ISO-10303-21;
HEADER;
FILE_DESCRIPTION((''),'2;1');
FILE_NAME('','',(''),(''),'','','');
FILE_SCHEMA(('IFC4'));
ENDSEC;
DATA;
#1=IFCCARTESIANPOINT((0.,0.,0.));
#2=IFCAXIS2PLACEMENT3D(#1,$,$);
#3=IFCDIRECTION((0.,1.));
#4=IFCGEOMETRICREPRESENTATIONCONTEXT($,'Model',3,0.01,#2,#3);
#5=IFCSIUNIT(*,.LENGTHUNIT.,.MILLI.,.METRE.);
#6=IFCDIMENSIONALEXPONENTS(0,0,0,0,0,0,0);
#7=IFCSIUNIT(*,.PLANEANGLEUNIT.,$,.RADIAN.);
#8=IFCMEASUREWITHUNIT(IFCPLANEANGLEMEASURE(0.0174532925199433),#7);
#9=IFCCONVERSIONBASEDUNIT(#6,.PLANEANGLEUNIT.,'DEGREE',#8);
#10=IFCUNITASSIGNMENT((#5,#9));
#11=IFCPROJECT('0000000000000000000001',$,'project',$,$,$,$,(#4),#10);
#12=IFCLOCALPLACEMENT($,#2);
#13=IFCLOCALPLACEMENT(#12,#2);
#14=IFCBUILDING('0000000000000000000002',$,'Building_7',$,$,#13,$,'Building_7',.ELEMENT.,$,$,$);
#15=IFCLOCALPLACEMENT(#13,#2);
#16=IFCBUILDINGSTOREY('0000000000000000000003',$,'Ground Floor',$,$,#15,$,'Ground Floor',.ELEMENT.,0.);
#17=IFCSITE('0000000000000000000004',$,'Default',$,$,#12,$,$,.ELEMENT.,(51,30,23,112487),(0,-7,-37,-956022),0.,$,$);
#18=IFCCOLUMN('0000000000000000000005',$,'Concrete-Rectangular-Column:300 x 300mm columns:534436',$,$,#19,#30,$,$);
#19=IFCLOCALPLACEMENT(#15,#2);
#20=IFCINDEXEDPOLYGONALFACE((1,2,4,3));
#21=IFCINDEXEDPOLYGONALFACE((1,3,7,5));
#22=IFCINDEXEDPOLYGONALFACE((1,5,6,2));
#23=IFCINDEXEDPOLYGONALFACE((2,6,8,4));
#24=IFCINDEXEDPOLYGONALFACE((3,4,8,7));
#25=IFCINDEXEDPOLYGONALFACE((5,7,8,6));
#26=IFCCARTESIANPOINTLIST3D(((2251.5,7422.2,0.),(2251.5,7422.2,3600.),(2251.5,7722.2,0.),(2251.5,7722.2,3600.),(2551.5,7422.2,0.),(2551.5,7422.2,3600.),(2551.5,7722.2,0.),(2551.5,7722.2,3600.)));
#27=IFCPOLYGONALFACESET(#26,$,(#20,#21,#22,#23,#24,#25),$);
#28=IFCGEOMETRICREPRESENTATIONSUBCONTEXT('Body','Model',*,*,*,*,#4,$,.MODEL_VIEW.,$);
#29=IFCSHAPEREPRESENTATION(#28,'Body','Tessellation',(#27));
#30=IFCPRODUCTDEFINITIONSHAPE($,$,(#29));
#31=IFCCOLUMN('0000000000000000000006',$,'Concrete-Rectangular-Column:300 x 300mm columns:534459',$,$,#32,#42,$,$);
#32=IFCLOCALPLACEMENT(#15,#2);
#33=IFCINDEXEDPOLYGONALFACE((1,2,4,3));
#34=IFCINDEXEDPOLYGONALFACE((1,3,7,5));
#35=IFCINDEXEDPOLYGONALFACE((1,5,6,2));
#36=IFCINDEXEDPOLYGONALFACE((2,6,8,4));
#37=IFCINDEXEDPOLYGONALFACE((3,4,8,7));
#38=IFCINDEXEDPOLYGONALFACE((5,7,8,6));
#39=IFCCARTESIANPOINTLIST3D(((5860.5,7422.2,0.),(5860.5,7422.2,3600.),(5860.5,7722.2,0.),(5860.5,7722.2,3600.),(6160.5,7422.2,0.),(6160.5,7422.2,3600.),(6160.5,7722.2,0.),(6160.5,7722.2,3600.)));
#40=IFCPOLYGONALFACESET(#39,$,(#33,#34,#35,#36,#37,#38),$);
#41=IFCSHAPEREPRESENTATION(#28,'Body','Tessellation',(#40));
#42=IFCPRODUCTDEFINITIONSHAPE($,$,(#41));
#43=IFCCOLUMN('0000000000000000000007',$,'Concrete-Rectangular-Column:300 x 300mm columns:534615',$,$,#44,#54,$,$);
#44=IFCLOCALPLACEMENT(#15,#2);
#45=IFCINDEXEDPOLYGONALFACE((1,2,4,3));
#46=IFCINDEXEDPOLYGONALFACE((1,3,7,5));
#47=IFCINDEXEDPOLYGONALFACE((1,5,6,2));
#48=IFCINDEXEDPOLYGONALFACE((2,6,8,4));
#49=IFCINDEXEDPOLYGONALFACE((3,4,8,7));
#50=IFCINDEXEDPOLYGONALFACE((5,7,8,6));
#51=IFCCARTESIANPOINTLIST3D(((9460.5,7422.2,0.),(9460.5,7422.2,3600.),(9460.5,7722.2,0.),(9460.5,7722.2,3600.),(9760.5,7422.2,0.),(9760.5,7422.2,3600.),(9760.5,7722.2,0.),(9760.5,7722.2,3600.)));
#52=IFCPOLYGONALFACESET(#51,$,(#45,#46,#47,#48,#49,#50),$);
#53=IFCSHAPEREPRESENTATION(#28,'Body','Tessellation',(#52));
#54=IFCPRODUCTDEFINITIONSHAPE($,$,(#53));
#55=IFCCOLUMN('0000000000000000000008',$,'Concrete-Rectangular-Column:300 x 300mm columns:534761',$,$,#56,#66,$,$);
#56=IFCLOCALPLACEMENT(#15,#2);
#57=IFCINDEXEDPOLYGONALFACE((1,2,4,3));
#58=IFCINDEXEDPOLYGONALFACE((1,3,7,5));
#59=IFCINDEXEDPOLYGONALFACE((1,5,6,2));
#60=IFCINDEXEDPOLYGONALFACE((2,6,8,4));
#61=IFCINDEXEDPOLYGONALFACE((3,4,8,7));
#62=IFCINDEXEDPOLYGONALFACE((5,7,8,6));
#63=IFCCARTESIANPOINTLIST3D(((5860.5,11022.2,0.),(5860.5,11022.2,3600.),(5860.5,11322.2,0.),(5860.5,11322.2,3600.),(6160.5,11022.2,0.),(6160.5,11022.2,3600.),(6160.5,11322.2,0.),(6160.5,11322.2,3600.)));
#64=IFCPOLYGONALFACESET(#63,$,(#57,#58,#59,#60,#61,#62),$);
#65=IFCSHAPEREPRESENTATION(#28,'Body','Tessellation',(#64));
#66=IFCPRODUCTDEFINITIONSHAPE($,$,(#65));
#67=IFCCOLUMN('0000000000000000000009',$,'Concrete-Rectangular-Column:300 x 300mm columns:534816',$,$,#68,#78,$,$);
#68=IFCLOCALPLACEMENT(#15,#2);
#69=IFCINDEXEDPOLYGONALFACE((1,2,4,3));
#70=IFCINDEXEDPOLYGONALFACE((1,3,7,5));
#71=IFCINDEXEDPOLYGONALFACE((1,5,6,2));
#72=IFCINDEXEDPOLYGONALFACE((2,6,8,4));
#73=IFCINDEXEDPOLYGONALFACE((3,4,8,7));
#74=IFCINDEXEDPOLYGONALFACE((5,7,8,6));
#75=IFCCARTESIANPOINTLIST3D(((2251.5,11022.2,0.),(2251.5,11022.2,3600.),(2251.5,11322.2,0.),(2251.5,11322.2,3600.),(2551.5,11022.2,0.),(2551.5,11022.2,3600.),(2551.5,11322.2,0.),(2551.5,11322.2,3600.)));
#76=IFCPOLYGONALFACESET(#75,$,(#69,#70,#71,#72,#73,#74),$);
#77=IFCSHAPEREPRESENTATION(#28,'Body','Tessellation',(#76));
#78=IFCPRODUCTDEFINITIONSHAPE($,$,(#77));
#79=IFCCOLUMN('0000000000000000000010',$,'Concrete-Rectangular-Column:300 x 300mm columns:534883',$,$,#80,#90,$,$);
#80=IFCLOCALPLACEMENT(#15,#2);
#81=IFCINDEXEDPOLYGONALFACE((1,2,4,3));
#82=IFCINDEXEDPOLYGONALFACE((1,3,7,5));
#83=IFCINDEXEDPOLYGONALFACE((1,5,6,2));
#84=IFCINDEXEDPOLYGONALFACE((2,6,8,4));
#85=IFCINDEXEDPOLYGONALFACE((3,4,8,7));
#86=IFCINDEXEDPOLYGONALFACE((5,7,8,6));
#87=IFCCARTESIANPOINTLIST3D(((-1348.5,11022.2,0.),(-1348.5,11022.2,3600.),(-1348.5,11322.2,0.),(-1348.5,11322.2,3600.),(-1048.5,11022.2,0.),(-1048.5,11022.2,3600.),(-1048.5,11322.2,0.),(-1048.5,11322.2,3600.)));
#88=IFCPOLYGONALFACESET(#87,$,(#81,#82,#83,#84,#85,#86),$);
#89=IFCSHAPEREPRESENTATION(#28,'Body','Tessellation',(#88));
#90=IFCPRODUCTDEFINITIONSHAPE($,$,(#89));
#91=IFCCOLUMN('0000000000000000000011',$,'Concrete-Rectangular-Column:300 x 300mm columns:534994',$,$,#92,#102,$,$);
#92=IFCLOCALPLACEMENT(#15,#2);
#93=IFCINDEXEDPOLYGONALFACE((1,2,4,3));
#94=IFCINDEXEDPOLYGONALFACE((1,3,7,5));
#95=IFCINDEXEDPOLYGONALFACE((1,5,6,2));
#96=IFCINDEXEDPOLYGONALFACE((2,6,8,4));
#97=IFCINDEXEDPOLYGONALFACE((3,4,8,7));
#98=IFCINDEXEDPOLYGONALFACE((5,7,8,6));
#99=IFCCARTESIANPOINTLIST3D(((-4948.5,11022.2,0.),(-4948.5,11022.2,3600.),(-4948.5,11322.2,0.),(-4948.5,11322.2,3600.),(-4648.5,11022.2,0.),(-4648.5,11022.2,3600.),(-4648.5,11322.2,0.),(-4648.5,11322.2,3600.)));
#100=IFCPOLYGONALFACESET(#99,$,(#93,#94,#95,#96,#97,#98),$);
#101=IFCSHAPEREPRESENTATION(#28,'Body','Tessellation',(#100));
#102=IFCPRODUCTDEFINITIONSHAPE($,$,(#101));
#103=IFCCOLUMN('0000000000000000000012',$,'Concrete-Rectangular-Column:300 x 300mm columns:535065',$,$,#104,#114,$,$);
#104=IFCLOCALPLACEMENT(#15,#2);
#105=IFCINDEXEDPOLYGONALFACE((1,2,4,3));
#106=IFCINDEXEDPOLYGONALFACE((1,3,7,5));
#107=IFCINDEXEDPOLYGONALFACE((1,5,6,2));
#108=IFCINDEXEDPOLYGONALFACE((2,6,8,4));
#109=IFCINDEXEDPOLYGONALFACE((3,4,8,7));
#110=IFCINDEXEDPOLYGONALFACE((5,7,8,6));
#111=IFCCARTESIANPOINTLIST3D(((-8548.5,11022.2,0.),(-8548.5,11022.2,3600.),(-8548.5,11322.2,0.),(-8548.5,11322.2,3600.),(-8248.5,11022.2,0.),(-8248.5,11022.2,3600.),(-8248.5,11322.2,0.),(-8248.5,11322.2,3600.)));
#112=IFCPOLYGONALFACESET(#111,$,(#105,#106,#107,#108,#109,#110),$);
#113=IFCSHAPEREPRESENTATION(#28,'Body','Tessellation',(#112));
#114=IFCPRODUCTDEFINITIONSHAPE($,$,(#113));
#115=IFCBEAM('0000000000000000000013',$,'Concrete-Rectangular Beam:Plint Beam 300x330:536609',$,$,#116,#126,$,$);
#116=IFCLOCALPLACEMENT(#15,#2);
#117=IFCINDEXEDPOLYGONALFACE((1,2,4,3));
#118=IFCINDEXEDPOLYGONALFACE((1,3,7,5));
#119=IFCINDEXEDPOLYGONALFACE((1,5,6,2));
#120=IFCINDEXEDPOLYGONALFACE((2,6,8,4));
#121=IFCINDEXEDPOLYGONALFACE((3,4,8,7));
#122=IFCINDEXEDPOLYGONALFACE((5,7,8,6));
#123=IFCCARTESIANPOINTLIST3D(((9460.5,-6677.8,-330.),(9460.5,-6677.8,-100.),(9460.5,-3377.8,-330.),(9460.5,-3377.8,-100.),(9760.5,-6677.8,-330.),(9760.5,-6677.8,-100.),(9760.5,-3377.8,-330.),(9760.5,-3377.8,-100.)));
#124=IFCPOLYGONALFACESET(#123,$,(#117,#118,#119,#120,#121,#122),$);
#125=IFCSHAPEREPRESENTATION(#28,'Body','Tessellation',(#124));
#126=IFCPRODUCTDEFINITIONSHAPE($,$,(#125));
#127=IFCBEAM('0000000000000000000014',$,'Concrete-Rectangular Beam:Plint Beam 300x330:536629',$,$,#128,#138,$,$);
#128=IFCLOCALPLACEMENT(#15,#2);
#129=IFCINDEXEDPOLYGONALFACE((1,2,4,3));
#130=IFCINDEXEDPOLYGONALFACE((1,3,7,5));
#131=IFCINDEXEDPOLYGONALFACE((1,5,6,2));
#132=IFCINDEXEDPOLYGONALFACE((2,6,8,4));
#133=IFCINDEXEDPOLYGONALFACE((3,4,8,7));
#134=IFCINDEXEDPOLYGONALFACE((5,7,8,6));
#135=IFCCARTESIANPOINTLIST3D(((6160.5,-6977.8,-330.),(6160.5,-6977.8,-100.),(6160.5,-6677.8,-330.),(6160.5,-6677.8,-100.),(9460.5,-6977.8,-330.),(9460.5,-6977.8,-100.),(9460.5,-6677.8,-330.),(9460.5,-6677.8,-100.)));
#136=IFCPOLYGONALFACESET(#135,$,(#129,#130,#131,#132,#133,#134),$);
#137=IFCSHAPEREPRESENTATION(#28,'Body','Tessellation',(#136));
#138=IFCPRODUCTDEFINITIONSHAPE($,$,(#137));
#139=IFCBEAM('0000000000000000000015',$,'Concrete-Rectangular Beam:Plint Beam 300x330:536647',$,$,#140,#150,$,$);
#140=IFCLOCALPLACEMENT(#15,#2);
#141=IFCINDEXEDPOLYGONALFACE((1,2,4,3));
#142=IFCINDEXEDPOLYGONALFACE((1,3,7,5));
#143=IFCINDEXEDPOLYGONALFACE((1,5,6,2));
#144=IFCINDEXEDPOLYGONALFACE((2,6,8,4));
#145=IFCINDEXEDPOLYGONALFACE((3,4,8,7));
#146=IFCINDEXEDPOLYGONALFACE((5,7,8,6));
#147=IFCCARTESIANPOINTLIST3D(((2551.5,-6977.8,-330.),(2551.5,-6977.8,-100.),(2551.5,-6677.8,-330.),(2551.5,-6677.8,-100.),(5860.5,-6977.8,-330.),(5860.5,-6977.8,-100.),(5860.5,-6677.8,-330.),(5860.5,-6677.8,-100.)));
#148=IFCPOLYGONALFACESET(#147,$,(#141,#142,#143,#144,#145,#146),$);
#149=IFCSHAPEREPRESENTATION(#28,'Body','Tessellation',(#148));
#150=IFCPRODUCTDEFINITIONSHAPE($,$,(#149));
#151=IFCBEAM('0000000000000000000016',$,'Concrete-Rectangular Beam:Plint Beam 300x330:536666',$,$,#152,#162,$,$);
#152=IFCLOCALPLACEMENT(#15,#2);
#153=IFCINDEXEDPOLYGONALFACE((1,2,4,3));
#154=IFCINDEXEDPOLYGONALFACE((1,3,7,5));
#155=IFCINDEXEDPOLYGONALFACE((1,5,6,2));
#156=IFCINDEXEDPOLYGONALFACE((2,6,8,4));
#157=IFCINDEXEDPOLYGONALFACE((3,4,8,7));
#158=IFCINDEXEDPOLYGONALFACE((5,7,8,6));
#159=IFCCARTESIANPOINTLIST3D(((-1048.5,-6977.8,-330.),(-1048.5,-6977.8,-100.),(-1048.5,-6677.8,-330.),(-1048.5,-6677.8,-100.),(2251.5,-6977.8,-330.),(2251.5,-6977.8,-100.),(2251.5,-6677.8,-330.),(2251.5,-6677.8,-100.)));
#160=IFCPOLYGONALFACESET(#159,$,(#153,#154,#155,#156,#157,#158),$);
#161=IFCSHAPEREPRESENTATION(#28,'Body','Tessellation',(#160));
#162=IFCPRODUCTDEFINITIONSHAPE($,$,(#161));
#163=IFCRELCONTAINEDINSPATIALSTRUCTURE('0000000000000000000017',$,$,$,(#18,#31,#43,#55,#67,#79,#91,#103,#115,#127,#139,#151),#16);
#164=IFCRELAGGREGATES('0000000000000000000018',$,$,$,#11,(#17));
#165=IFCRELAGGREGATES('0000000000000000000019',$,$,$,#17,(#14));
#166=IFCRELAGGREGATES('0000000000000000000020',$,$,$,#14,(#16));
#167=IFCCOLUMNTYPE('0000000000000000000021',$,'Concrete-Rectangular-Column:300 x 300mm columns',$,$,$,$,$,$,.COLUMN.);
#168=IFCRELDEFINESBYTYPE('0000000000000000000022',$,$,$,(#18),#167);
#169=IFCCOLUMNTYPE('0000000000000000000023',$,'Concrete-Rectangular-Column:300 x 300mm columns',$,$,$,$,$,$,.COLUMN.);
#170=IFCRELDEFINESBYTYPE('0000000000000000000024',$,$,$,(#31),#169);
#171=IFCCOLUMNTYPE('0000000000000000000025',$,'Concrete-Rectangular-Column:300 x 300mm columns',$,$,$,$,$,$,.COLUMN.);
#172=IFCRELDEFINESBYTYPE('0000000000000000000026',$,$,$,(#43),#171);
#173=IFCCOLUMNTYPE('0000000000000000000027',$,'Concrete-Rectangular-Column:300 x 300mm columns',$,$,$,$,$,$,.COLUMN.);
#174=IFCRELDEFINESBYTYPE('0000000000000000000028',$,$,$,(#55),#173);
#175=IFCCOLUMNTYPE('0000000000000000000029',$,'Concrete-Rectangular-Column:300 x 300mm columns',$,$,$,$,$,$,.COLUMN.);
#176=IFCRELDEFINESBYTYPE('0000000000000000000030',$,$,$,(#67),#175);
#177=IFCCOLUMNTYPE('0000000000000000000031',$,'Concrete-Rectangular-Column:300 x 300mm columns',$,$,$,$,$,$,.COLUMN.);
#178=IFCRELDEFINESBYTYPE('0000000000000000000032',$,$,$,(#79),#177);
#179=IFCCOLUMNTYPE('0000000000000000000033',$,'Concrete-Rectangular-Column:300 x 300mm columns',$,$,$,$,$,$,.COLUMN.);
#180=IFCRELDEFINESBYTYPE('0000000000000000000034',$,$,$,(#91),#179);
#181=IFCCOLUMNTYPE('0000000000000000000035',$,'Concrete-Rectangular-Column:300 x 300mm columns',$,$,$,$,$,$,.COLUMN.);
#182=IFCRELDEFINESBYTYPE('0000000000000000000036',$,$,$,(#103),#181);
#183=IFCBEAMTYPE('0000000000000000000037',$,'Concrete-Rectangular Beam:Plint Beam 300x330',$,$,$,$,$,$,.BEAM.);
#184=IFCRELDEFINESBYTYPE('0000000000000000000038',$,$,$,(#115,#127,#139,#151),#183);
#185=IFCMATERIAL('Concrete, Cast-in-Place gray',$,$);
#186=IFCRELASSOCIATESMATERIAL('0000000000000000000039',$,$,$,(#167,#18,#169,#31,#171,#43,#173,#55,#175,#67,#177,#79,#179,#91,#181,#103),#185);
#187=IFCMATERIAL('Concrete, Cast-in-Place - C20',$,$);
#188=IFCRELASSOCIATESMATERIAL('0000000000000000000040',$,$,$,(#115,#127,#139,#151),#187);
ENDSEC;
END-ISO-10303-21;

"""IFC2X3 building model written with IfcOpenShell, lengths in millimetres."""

from ifc_helpers import new_model, entity, si_unit, converted_unit, direction, frame, frame_2d, origin, place, context, subcontext, project, spatial, rectangle, extrude, source, transform, mapped, material, type_object, type_shapes, element, save


model = new_model("IFC2X3")

# Units and contexts
model_context = context("Model", 3, precision=0.01, world=origin(), true_north=direction((0.0, 1.0)))
body_context = subcontext(model_context, "Body", "Model", "MODEL_VIEW")
ifc_project = project(units=[si_unit("LENGTHUNIT", "METRE", prefix="MILLI"), converted_unit("PLANEANGLEUNIT", "DEGREE", entity("IfcPlaneAngleMeasure", 0.0174532925199433), si_unit("PLANEANGLEUNIT", "RADIAN"), dimensions=[0, 0, 0, 0, 0, 0, 0])], contexts=[model_context])

# Site, building, storey
site_placement = place(None, origin())
site = spatial("IfcSite", under=ifc_project, at=site_placement, Name="Default", CompositionType="ELEMENT", RefLatitude=(51, 30, 23, 112487), RefLongitude=(0, -7, -37, -956022), RefElevation=0.0)
building_placement = place(site_placement, origin())
building = spatial("IfcBuilding", under=site, at=building_placement, Name="Building_7", LongName="Building_7", CompositionType="ELEMENT")
storey_placement = place(building_placement, origin())
storey = spatial("IfcBuildingStorey", under=building, at=storey_placement, Name="Ground Floor", LongName="Ground Floor", CompositionType="ELEMENT", Elevation=0.0)

# Columns
ifc_material_1 = material(Name="Concrete, Cast-in-Place gray")
column_type_1 = type_object("IfcColumnType", Name="Concrete-Rectangular-Column:300 x 300mm columns", PredefinedType="COLUMN", material=ifc_material_1)
shared_shape_1 = source(origin(), body_context, "Body", "SweptSolid", [
    extrude(rectangle(XDim=300.0, YDim=300.0, at=frame_2d((0.0, 0.0), x_axis=(1.0, 0.0))), frame((2401.5, 7572.2, 0.0), z_axis=(0.0, 0.0, 1.0), x_axis=(-1.0, 0.0, 0.0)), (0.0, 0.0, 1.0), 3600.0),
])
type_shapes(column_type_1, [shared_shape_1])
column_1_placement = place(storey_placement, origin())
element("IfcColumn", 1, at=column_1_placement, inside=storey, type_object=column_type_1, material=ifc_material_1, Name="Concrete-Rectangular-Column:300 x 300mm columns:534436", context=body_context, shape_type="MappedRepresentation", body=[
    mapped(shared_shape_1, transform((0.0, 0.0, 0.0), scale=1.0)),
])
column_type_2 = type_object("IfcColumnType", Name="Concrete-Rectangular-Column:300 x 300mm columns", PredefinedType="COLUMN", material=ifc_material_1)
shared_shape_2 = source(origin(), body_context, "Body", "SweptSolid", [
    extrude(rectangle(XDim=300.0, YDim=300.0, at=frame_2d((0.0, 0.0), x_axis=(1.0, 0.0))), frame((6010.5, 7572.2, 0.0), z_axis=(0.0, 0.0, 1.0), x_axis=(-1.0, 0.0, 0.0)), (0.0, 0.0, 1.0), 3600.0),
])
type_shapes(column_type_2, [shared_shape_2])
column_2_placement = place(storey_placement, origin())
element("IfcColumn", 2, at=column_2_placement, inside=storey, type_object=column_type_2, material=ifc_material_1, Name="Concrete-Rectangular-Column:300 x 300mm columns:534459", context=body_context, shape_type="MappedRepresentation", body=[
    mapped(shared_shape_2, transform((0.0, 0.0, 0.0), scale=1.0)),
])
column_type_3 = type_object("IfcColumnType", Name="Concrete-Rectangular-Column:300 x 300mm columns", PredefinedType="COLUMN", material=ifc_material_1)
shared_shape_3 = source(origin(), body_context, "Body", "SweptSolid", [
    extrude(rectangle(XDim=300.0, YDim=300.0, at=frame_2d((0.0, 0.0), x_axis=(1.0, 0.0))), frame((9610.5, 7572.2, 0.0), z_axis=(0.0, 0.0, 1.0), x_axis=(-1.0, 0.0, 0.0)), (0.0, 0.0, 1.0), 3600.0),
])
type_shapes(column_type_3, [shared_shape_3])
column_3_placement = place(storey_placement, origin())
element("IfcColumn", 3, at=column_3_placement, inside=storey, type_object=column_type_3, material=ifc_material_1, Name="Concrete-Rectangular-Column:300 x 300mm columns:534615", context=body_context, shape_type="MappedRepresentation", body=[
    mapped(shared_shape_3, transform((0.0, 0.0, 0.0), scale=1.0)),
])
column_type_4 = type_object("IfcColumnType", Name="Concrete-Rectangular-Column:300 x 300mm columns", PredefinedType="COLUMN", material=ifc_material_1)
shared_shape_4 = source(origin(), body_context, "Body", "SweptSolid", [
    extrude(rectangle(XDim=300.0, YDim=300.0, at=frame_2d((0.0, 0.0), x_axis=(1.0, 0.0))), frame((6010.5, 11172.2, 0.0), z_axis=(0.0, 0.0, 1.0), x_axis=(-1.0, 0.0, 0.0)), (0.0, 0.0, 1.0), 3600.0),
])
type_shapes(column_type_4, [shared_shape_4])
column_4_placement = place(storey_placement, origin())
element("IfcColumn", 4, at=column_4_placement, inside=storey, type_object=column_type_4, material=ifc_material_1, Name="Concrete-Rectangular-Column:300 x 300mm columns:534761", context=body_context, shape_type="MappedRepresentation", body=[
    mapped(shared_shape_4, transform((0.0, 0.0, 0.0), scale=1.0)),
])
column_type_5 = type_object("IfcColumnType", Name="Concrete-Rectangular-Column:300 x 300mm columns", PredefinedType="COLUMN", material=ifc_material_1)
shared_shape_5 = source(origin(), body_context, "Body", "SweptSolid", [
    extrude(rectangle(XDim=300.0, YDim=300.0, at=frame_2d((0.0, 0.0), x_axis=(1.0, 0.0))), frame((2401.5, 11172.2, 0.0), z_axis=(0.0, 0.0, 1.0), x_axis=(-1.0, 0.0, 0.0)), (0.0, 0.0, 1.0), 3600.0),
])
type_shapes(column_type_5, [shared_shape_5])
column_5_placement = place(storey_placement, origin())
element("IfcColumn", 5, at=column_5_placement, inside=storey, type_object=column_type_5, material=ifc_material_1, Name="Concrete-Rectangular-Column:300 x 300mm columns:534816", context=body_context, shape_type="MappedRepresentation", body=[
    mapped(shared_shape_5, transform((0.0, 0.0, 0.0), scale=1.0)),
])
column_type_6 = type_object("IfcColumnType", Name="Concrete-Rectangular-Column:300 x 300mm columns", PredefinedType="COLUMN", material=ifc_material_1)
shared_shape_6 = source(origin(), body_context, "Body", "SweptSolid", [
    extrude(rectangle(XDim=300.0, YDim=300.0, at=frame_2d((0.0, 0.0), x_axis=(1.0, 0.0))), frame((-1198.5, 11172.2, 0.0), z_axis=(0.0, 0.0, 1.0), x_axis=(-1.0, 0.0, 0.0)), (0.0, 0.0, 1.0), 3600.0),
])
type_shapes(column_type_6, [shared_shape_6])
column_6_placement = place(storey_placement, origin())
element("IfcColumn", 6, at=column_6_placement, inside=storey, type_object=column_type_6, material=ifc_material_1, Name="Concrete-Rectangular-Column:300 x 300mm columns:534883", context=body_context, shape_type="MappedRepresentation", body=[
    mapped(shared_shape_6, transform((0.0, 0.0, 0.0), scale=1.0)),
])
column_type_7 = type_object("IfcColumnType", Name="Concrete-Rectangular-Column:300 x 300mm columns", PredefinedType="COLUMN", material=ifc_material_1)
shared_shape_7 = source(origin(), body_context, "Body", "SweptSolid", [
    extrude(rectangle(XDim=300.0, YDim=300.0, at=frame_2d((0.0, 0.0), x_axis=(1.0, 0.0))), frame((-4798.5, 11172.2, 0.0), z_axis=(0.0, 0.0, 1.0), x_axis=(-1.0, 0.0, 0.0)), (0.0, 0.0, 1.0), 3600.0),
])
type_shapes(column_type_7, [shared_shape_7])
column_7_placement = place(storey_placement, origin())
element("IfcColumn", 7, at=column_7_placement, inside=storey, type_object=column_type_7, material=ifc_material_1, Name="Concrete-Rectangular-Column:300 x 300mm columns:534994", context=body_context, shape_type="MappedRepresentation", body=[
    mapped(shared_shape_7, transform((0.0, 0.0, 0.0), scale=1.0)),
])
column_type_8 = type_object("IfcColumnType", Name="Concrete-Rectangular-Column:300 x 300mm columns", PredefinedType="COLUMN", material=ifc_material_1)
shared_shape_8 = source(origin(), body_context, "Body", "SweptSolid", [
    extrude(rectangle(XDim=300.0, YDim=300.0, at=frame_2d((0.0, 0.0), x_axis=(1.0, 0.0))), frame((-8398.5, 11172.2, 0.0), z_axis=(0.0, 0.0, 1.0), x_axis=(-1.0, 0.0, 0.0)), (0.0, 0.0, 1.0), 3600.0),
])
type_shapes(column_type_8, [shared_shape_8])
column_8_placement = place(storey_placement, origin())
element("IfcColumn", 8, at=column_8_placement, inside=storey, type_object=column_type_8, material=ifc_material_1, Name="Concrete-Rectangular-Column:300 x 300mm columns:535065", context=body_context, shape_type="MappedRepresentation", body=[
    mapped(shared_shape_8, transform((0.0, 0.0, 0.0), scale=1.0)),
])

# Beams
ifc_material_2 = material(Name="Concrete, Cast-in-Place - C20")
beam_type = type_object("IfcBeamType", Name="Concrete-Rectangular Beam:Plint Beam 300x330", PredefinedType="BEAM")
beam_1_placement = place(storey_placement, frame((9610.5, -3227.8, 0.0), z_axis=(0.0, 0.0, 1.0), x_axis=(0.0, -1.0, 0.0)))
element("IfcBeam", 9, at=beam_1_placement, inside=storey, type_object=beam_type, material=ifc_material_2, Name="Concrete-Rectangular Beam:Plint Beam 300x330:536609", context=body_context, shape_type="SweptSolid", body=[
    extrude(rectangle(XDim=230.0, YDim=300.0, at=frame_2d((0.0, 0.0), x_axis=(1.0, 0.0))), frame((150.0, 0.0, -215.0), z_axis=(1.0, 0.0, 0.0), x_axis=(0.0, 0.0, -1.0)), (0.0, 0.0, 1.0), 3300.0),
])
beam_2_placement = place(storey_placement, frame((9610.5, -6827.8, 0.0), z_axis=(0.0, 0.0, 1.0), x_axis=(-1.0, 0.0, 0.0)))
element("IfcBeam", 10, at=beam_2_placement, inside=storey, type_object=beam_type, material=ifc_material_2, Name="Concrete-Rectangular Beam:Plint Beam 300x330:536629", context=body_context, shape_type="SweptSolid", body=[
    extrude(rectangle(XDim=230.0, YDim=300.0, at=frame_2d((0.0, 0.0), x_axis=(1.0, 0.0))), frame((150.0, 0.0, -215.0), z_axis=(1.0, 0.0, 0.0), x_axis=(0.0, 0.0, -1.0)), (0.0, 0.0, 1.0), 3300.0),
])
beam_3_placement = place(storey_placement, frame((6010.5, -6827.8, 0.0), z_axis=(0.0, 0.0, 1.0), x_axis=(-1.0, 0.0, 0.0)))
element("IfcBeam", 11, at=beam_3_placement, inside=storey, type_object=beam_type, material=ifc_material_2, Name="Concrete-Rectangular Beam:Plint Beam 300x330:536647", context=body_context, shape_type="SweptSolid", body=[
    extrude(rectangle(XDim=230.0, YDim=300.0, at=frame_2d((0.0, 0.0), x_axis=(1.0, 0.0))), frame((150.0, 0.0, -215.0), z_axis=(1.0, 0.0, 0.0), x_axis=(0.0, 0.0, -1.0)), (0.0, 0.0, 1.0), 3308.9),
])
beam_4_placement = place(storey_placement, frame((2401.5, -6827.8, 0.0), z_axis=(0.0, 0.0, 1.0), x_axis=(-1.0, 0.0, 0.0)))
element("IfcBeam", 12, at=beam_4_placement, inside=storey, type_object=beam_type, material=ifc_material_2, Name="Concrete-Rectangular Beam:Plint Beam 300x330:536666", context=body_context, shape_type="SweptSolid", body=[
    extrude(rectangle(XDim=230.0, YDim=300.0, at=frame_2d((0.0, 0.0), x_axis=(1.0, 0.0))), frame((150.0, 0.0, -215.0), z_axis=(1.0, 0.0, 0.0), x_axis=(0.0, 0.0, -1.0)), (0.0, 0.0, 1.0), 3300.0),
])

save(model, "model.ifc")
